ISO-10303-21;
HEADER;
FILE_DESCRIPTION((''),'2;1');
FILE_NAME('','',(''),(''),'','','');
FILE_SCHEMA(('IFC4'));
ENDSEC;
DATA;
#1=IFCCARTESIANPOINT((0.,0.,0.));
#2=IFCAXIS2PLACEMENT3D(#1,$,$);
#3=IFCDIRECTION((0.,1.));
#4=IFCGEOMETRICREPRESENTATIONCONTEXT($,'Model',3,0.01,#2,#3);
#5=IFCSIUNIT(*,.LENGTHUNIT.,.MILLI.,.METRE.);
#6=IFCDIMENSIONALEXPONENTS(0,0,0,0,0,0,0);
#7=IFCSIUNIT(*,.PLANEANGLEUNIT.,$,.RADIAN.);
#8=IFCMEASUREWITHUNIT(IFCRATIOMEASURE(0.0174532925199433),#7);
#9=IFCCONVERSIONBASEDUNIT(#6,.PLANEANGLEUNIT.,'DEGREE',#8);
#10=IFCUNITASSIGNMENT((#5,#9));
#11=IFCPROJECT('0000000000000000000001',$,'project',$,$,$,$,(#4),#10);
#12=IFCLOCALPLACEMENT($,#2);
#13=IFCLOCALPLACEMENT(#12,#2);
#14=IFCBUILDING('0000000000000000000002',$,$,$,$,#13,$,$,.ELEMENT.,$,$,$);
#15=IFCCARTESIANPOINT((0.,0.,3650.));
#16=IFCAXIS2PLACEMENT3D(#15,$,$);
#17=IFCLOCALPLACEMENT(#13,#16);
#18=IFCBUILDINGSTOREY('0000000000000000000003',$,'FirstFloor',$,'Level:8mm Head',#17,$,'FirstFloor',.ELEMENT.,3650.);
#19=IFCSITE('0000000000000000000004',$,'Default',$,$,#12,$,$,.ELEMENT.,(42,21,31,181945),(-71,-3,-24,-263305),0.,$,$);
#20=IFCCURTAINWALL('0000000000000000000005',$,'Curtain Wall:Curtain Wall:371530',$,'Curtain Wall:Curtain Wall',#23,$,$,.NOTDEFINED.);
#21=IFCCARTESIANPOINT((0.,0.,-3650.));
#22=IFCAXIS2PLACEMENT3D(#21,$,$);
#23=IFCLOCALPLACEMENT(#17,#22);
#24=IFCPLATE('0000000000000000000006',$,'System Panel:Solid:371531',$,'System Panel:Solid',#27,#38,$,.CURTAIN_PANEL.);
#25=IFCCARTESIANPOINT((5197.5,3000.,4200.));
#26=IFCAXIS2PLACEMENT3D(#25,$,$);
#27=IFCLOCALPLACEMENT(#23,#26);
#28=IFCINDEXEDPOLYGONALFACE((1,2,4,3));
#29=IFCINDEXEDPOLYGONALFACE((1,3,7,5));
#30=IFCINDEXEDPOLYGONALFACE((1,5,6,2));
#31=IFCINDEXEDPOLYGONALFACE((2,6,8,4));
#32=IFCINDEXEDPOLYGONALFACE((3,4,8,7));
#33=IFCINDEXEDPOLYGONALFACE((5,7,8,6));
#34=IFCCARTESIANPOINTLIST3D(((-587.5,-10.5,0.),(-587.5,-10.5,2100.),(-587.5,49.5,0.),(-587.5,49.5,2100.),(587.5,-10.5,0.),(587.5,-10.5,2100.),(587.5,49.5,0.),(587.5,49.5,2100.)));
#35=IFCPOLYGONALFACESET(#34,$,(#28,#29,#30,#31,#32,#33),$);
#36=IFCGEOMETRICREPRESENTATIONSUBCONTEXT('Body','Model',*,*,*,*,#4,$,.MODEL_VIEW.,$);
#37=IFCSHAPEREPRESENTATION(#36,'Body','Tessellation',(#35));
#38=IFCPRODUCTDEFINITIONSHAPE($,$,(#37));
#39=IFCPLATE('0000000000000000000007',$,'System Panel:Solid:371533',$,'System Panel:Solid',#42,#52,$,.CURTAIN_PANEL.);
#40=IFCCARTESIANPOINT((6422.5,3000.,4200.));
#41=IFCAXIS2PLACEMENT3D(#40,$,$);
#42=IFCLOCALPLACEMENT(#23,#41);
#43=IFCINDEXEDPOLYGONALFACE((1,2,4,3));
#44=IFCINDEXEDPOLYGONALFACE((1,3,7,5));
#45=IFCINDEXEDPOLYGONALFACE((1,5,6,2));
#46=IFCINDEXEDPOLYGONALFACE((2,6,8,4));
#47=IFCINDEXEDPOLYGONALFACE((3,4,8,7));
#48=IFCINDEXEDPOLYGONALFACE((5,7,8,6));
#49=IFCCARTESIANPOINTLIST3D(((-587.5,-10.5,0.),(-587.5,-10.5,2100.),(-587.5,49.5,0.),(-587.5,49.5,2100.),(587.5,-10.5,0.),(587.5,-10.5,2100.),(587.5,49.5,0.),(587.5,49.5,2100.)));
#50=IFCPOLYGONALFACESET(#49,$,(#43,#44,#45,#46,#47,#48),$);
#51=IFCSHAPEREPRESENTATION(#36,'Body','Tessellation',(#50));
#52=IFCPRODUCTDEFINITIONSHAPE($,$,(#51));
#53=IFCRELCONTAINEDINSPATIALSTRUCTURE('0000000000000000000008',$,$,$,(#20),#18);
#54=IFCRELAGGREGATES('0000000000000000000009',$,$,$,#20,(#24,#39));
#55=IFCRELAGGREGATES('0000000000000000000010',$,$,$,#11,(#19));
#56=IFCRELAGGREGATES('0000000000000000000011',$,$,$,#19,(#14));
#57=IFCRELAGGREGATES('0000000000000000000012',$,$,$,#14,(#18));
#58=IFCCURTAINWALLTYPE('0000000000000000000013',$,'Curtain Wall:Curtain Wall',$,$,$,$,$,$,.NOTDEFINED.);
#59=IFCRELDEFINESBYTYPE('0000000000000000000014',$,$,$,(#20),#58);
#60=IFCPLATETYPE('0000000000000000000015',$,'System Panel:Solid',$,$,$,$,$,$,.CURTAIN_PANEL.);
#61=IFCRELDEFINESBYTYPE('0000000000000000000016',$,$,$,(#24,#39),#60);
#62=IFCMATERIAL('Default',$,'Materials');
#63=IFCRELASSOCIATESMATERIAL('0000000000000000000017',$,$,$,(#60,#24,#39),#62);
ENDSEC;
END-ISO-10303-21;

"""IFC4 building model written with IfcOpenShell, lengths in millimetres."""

from ifc_helpers import new_model, entity, si_unit, converted_unit, direction, frame, origin, origin_2d_with_axis, place, context, subcontext, project, spatial, rectangle, extrude, shape, source, transform, mapped, material, type_object, type_shapes, element, aggregate, save


model = new_model("IFC4")

# Units and contexts
model_context = context("Model", 3, precision=0.01, world=origin(), true_north=direction((0.0, 1.0)))
body_context = subcontext(model_context, "Body", "Model", "MODEL_VIEW")
footprint_context = subcontext(model_context, "FootPrint", "Model", "MODEL_VIEW")
ifc_project = project(units=[si_unit("LENGTHUNIT", "METRE", prefix="MILLI"), converted_unit("PLANEANGLEUNIT", "DEGREE", entity("IfcRatioMeasure", 0.0174532925199433), si_unit("PLANEANGLEUNIT", "RADIAN"), dimensions=[0, 0, 0, 0, 0, 0, 0])], contexts=[model_context])

# Site, building, storey
site_placement = place(None, origin())
site = spatial("IfcSite", under=ifc_project, at=site_placement, Name="Default", CompositionType="ELEMENT", RefLatitude=(42, 21, 31, 181945), RefLongitude=(-71, -3, -24, -263305), RefElevation=0.0)
building_placement = place(site_placement, origin())
building = spatial("IfcBuilding", under=site, at=building_placement, CompositionType="ELEMENT")
storey_placement = place(building_placement, frame((0.0, 0.0, 3650.0)))
storey = spatial("IfcBuildingStorey", under=building, at=storey_placement, Name="FirstFloor", ObjectType="Level:8mm Head", LongName="FirstFloor", CompositionType="ELEMENT", Elevation=3650.0)

# Curtain wall
curtain_wall_type = type_object("IfcCurtainWallType", Name="Curtain Wall:Curtain Wall", PredefinedType="NOTDEFINED")
curtain_wall_placement = place(storey_placement, frame((0.0, 0.0, -3650.0)))
curtain_wall = element("IfcCurtainWall", 1, at=curtain_wall_placement, inside=storey, type_object=curtain_wall_type, Name="Curtain Wall:Curtain Wall:371530", ObjectType="Curtain Wall:Curtain Wall", PredefinedType="NOTDEFINED")

# Plates
ifc_material_1 = material(Name="Default", Category="Materials")
plate_type = type_object("IfcPlateType", Name="System Panel:Solid", PredefinedType="CURTAIN_PANEL", material=ifc_material_1)
shared_shape_1 = source(origin(), body_context, "Body", "SweptSolid", [
    extrude(rectangle(XDim=60.0, YDim=1175.0, at=origin_2d_with_axis()), frame((0.0, 19.5, 0.0), z_axis=(0.0, 0.0, 1.0), x_axis=(0.0, 1.0, 0.0)), (0.0, 0.0, 1.0), 2100.0),
])
cartesian_point = entity("IfcCartesianPoint", [587.5, -10.5])
shared_shape_2 = source(origin(), footprint_context, "FootPrint", "Curve2D", [
    entity("IfcPolyline", [cartesian_point, entity("IfcCartesianPoint", [587.5, 49.5]), entity("IfcCartesianPoint", [-587.5, 49.5]), entity("IfcCartesianPoint", [-587.5, -10.5]), cartesian_point]),
])
type_shapes(plate_type, [shared_shape_1, shared_shape_2])
plate_1_placement = place(curtain_wall_placement, frame((5197.5, 3000.0, 4200.0)))
plate_1 = element("IfcPlate", 2, at=plate_1_placement, type_object=plate_type, material=ifc_material_1, Name="System Panel:Solid:371531", ObjectType="System Panel:Solid", PredefinedType="CURTAIN_PANEL", shapes=[
    shape(body_context, "Body", "MappedRepresentation", [mapped(shared_shape_1, transform((0.0, 0.0, 0.0), scale=1.0))]),
    shape(body_context, "Body", "MappedRepresentation", [mapped(shared_shape_2, transform((0.0, 0.0, 0.0), scale=1.0))]),
])
plate_2_placement = place(curtain_wall_placement, frame((6422.5, 3000.0, 4200.0)))
plate_2 = element("IfcPlate", 3, at=plate_2_placement, type_object=plate_type, material=ifc_material_1, Name="System Panel:Solid:371533", ObjectType="System Panel:Solid", PredefinedType="CURTAIN_PANEL", shapes=[
    shape(body_context, "Body", "MappedRepresentation", [mapped(shared_shape_1, transform((0.0, 0.0, 0.0), scale=1.0))]),
    shape(body_context, "Body", "MappedRepresentation", [mapped(shared_shape_2, transform((0.0, 0.0, 0.0), scale=1.0))]),
])
aggregate(curtain_wall, [plate_1, plate_2])

save(model, "model.ifc")
